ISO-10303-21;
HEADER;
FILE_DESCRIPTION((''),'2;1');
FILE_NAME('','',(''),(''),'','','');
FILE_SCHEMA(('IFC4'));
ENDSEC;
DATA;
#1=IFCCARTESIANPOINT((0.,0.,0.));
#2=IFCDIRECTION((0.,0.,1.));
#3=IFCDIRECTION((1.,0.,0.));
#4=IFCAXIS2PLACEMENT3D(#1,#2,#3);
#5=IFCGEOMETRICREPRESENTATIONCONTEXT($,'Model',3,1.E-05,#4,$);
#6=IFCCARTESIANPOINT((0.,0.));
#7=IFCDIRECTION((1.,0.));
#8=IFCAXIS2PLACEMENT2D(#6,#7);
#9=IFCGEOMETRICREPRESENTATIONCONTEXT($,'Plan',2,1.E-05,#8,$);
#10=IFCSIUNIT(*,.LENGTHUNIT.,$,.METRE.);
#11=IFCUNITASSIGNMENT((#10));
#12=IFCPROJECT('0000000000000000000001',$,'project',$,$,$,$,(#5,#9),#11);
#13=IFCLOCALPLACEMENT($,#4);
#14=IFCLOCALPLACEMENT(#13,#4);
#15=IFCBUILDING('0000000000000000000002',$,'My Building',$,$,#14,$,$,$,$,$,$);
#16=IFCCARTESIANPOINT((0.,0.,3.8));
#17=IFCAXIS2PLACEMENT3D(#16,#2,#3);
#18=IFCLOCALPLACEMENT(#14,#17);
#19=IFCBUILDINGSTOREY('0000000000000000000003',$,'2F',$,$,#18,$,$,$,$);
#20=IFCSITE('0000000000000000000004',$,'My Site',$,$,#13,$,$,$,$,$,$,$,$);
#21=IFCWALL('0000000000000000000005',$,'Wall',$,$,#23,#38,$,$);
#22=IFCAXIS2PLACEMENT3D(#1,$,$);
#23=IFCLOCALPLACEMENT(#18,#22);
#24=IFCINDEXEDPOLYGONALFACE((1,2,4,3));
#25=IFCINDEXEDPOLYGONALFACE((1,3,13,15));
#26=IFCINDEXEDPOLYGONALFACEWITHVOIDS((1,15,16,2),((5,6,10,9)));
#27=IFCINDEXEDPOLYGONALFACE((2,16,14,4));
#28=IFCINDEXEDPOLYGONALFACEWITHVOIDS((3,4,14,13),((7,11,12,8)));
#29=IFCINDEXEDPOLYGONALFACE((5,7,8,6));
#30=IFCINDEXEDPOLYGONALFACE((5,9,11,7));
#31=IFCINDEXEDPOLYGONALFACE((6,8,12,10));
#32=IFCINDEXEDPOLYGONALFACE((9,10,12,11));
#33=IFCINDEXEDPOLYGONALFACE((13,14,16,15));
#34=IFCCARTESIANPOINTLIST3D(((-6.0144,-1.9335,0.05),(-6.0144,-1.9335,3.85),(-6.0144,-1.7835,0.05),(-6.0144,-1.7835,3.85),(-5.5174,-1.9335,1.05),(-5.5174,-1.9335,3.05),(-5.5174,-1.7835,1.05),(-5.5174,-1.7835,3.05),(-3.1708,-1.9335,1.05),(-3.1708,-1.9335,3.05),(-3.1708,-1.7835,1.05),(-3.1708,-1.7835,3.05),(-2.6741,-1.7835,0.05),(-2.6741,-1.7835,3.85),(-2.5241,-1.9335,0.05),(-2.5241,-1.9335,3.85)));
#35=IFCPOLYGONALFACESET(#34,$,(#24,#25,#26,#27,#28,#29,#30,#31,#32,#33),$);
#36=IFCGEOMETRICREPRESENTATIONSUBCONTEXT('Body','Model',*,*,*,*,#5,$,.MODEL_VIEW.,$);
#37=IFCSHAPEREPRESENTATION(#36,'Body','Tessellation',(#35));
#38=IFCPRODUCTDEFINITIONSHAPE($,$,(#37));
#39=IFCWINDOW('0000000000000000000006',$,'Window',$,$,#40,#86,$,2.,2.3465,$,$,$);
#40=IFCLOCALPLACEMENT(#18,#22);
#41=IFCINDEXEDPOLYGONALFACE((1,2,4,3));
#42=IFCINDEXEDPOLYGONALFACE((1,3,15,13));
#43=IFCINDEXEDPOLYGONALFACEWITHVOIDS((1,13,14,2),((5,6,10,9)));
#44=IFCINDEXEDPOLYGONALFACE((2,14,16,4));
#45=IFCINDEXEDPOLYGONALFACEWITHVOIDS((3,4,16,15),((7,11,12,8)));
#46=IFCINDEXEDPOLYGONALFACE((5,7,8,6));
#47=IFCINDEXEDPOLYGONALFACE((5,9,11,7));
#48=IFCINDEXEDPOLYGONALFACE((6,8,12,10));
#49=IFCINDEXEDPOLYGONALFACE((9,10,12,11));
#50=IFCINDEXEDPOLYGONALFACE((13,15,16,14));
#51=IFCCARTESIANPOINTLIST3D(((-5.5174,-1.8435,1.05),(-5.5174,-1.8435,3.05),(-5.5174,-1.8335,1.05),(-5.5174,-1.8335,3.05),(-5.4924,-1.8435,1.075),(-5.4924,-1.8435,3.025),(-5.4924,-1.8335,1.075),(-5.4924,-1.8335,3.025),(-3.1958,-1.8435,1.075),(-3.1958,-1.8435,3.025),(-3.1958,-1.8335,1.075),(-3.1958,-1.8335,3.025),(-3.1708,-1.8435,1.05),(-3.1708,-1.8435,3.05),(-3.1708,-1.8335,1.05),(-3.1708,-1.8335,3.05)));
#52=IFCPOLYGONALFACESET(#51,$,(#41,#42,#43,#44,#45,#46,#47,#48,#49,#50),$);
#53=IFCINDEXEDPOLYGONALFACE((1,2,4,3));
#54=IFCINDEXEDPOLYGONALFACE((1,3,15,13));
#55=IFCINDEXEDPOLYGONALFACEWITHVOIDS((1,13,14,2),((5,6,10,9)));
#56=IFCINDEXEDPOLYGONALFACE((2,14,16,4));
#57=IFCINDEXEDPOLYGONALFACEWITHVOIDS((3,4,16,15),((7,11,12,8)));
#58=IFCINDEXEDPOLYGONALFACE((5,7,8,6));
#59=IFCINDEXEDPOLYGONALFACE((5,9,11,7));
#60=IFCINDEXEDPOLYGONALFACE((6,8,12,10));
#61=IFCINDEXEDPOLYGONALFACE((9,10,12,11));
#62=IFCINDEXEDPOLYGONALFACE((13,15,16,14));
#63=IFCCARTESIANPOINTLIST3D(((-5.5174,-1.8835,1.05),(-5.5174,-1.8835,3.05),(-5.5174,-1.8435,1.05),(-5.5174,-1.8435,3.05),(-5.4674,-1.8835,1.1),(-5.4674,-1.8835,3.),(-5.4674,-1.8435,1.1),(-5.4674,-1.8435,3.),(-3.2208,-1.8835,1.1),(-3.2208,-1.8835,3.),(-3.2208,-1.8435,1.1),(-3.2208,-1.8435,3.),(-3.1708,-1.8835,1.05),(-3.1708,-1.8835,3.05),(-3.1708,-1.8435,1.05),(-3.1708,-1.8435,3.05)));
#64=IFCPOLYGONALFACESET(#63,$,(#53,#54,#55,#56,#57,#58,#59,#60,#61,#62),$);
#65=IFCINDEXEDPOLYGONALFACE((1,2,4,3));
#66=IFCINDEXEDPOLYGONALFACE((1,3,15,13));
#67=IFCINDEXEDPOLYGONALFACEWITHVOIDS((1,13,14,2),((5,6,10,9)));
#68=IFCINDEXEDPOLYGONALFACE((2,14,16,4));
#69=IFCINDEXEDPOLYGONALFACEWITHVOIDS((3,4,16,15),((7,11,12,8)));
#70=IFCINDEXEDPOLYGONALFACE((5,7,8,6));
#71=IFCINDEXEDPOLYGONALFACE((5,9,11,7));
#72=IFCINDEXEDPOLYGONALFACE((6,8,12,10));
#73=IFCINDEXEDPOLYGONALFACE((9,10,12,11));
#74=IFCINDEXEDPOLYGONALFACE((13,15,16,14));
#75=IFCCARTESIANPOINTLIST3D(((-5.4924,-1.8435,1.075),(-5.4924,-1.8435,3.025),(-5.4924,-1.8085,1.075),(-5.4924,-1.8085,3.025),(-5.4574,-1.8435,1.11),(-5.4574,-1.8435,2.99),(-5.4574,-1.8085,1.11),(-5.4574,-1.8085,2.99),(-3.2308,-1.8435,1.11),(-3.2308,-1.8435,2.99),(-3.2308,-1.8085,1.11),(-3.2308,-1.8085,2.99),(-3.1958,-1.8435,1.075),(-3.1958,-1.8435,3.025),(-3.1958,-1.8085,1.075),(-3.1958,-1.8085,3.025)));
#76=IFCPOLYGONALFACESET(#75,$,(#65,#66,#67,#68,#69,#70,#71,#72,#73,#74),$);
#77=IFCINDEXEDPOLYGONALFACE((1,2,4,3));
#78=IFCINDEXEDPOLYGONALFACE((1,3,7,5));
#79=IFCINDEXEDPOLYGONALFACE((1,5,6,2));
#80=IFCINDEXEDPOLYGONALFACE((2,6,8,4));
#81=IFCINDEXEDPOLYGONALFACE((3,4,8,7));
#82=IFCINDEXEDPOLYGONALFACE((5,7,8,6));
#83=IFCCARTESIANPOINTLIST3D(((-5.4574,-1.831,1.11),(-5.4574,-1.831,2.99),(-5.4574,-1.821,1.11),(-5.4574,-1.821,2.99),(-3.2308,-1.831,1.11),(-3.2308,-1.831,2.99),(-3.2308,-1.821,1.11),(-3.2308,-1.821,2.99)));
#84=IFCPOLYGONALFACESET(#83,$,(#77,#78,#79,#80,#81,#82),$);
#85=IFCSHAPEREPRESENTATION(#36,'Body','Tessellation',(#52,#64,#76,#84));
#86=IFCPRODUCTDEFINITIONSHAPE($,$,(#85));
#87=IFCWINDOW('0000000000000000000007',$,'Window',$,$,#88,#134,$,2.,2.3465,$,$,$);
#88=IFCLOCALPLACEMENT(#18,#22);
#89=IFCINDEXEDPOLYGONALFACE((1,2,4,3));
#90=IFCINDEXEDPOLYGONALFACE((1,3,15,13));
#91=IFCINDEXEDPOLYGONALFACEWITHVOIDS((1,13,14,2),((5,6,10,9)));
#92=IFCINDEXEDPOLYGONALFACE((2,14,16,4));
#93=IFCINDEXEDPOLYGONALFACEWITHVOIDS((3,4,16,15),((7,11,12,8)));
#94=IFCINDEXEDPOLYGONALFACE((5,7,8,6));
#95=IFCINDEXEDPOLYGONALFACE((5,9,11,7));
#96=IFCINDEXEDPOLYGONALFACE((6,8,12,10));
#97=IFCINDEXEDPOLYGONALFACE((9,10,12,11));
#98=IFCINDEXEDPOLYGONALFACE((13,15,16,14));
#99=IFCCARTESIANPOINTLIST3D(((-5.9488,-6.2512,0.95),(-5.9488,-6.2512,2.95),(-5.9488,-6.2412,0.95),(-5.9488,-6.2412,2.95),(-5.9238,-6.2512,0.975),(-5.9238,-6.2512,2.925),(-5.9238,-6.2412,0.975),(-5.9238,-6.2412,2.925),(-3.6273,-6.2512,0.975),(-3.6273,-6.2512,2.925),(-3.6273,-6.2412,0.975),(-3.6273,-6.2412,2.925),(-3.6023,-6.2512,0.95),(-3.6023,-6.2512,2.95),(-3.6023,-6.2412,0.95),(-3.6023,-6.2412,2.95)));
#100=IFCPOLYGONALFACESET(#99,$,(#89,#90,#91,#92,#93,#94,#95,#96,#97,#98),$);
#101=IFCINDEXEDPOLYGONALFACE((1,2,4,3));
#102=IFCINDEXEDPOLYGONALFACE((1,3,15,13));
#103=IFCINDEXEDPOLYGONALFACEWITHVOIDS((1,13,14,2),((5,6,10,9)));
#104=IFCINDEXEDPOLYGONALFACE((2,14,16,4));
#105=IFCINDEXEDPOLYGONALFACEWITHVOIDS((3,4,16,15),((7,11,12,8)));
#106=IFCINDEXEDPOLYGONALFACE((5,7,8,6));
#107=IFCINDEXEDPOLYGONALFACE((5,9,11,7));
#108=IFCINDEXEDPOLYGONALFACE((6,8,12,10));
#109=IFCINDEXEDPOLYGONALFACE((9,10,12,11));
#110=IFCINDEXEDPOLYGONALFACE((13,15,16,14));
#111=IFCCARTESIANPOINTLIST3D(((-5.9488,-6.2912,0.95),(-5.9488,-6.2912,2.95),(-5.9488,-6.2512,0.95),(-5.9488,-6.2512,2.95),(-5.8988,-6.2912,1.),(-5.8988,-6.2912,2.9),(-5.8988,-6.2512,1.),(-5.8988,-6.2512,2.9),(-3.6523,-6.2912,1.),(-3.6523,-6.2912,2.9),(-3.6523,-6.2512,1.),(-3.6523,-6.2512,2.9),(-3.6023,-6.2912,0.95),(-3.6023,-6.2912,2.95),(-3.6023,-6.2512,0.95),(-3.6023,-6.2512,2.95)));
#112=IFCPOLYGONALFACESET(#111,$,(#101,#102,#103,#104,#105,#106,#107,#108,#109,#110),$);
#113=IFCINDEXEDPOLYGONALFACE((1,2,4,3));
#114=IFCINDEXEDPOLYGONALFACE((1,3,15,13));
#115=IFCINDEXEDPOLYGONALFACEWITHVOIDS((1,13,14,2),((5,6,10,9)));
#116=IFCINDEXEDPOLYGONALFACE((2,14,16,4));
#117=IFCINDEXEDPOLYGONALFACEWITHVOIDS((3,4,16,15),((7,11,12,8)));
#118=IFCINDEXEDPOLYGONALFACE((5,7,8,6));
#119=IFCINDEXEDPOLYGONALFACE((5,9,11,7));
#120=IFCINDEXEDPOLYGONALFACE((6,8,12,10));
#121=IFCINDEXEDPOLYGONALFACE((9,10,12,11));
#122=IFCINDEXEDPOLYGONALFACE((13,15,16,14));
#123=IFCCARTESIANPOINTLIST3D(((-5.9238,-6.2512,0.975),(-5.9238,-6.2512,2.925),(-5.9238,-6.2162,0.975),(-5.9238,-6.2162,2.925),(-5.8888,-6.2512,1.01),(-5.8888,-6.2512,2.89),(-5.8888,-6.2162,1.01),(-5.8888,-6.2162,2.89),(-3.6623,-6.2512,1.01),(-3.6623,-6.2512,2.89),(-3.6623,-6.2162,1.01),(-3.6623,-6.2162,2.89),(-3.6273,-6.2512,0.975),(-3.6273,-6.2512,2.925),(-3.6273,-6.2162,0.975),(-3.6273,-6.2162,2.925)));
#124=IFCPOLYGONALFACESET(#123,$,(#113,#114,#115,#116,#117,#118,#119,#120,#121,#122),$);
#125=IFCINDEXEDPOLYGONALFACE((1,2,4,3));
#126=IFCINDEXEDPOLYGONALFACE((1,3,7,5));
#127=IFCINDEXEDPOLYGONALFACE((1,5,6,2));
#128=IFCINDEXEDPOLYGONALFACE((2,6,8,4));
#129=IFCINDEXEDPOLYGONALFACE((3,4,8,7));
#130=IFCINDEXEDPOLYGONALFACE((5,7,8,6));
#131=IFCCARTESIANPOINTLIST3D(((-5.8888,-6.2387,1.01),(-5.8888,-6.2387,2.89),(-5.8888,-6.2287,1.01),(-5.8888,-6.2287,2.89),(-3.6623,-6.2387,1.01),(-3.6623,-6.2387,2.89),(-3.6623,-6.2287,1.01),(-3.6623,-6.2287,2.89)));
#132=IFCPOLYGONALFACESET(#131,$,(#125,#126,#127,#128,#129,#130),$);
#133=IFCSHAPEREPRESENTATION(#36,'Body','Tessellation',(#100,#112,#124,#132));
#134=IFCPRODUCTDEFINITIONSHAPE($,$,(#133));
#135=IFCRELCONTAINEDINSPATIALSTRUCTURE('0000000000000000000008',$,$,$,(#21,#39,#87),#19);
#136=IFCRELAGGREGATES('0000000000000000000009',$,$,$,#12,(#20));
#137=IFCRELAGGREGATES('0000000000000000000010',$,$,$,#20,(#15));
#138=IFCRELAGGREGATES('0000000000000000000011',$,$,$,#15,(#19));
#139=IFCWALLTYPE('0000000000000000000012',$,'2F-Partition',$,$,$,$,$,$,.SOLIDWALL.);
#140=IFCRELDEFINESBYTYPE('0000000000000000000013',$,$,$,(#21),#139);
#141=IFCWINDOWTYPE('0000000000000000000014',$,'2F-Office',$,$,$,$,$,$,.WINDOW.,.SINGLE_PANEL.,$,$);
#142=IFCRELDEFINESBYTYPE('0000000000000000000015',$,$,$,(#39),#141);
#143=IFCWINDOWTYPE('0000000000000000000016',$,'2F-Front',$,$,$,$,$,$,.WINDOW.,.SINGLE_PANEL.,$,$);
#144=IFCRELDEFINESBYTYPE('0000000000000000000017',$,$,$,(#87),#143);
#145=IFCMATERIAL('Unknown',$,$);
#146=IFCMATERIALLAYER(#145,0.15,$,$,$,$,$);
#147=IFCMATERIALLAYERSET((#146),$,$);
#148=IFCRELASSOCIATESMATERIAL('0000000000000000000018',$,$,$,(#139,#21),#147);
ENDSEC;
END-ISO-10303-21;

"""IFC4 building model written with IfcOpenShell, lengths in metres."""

from ifc_helpers import new_model, entity, si_unit, frame, origin_with_axes, origin_2d_with_axis, place, context, subcontext, project, spatial, line, indexed_curve, outline, extrude, shape, source, transform, mapped, material, layer, layer_set, layer_usage, type_object, type_shapes, element, fill, save


model = new_model("IFC4")

# Units and contexts
model_context = context("Model", 3, precision=1e-05, world=origin_with_axes())
plan_context = context("Plan", 2, precision=1e-05, world=origin_2d_with_axis())
body_context_1 = subcontext(model_context, "Body", "Model", "MODEL_VIEW")
body_context_2 = subcontext(plan_context, "Body", "Plan", "PLAN_VIEW")
ifc_project = project(units=[si_unit("LENGTHUNIT", "METRE")], contexts=[model_context, plan_context])

# Site, building, storey
site_placement = place(None, origin_with_axes())
site = spatial("IfcSite", under=ifc_project, at=site_placement, Name="My Site")
building_placement = place(site_placement, origin_with_axes())
building = spatial("IfcBuilding", under=site, at=building_placement, Name="My Building")
storey_placement = place(building_placement, frame((0.0, 0.0, 3.8), z_axis=(0.0, 0.0, 1.0), x_axis=(1.0, 0.0, 0.0)))
storey = spatial("IfcBuildingStorey", under=building, at=storey_placement, Name="2F")

# Shared definitions
ifc_material = material(Name="Unknown")

# Shared definitions
ifc_layer_1 = layer(ifc_material, 0.15)
ifc_layer_set_1 = layer_set([ifc_layer_1])
wall_type_1 = type_object("IfcWallType", Name="2F-Partition", PredefinedType="SOLIDWALL", material=ifc_layer_set_1)

# Wall, opening, window
ifc_layer_usage_1 = layer_usage(ifc_layer_set_1, "AXIS2", "POSITIVE", 0.0)
wall_1_placement = place(storey_placement, frame((-2.6741, -1.7835, 0.05), z_axis=(0.0, 0.0, 1.0), x_axis=(-1.0, 0.0, 0.0)))
wall_1 = element("IfcWall", 1, at=wall_1_placement, inside=storey, type_object=wall_type_1, material=ifc_layer_usage_1, Name="Wall", context=body_context_1, shape_type="SweptSolid", body=[
    extrude(outline(indexed_curve([(0.0, 0.0), (-0.15, 0.15), (3.3403, 0.15), (3.3403, 0.0)], segments=[line(1, 2, 3, 4, 1)])), origin_with_axes(), (0.0, 0.0, 1.0), 3.8),
])
shared_shape_1 = source(origin_with_axes(), body_context_1, "Body", "SweptSolid", [
    extrude(outline(indexed_curve([(0.0, 0.0), (2.3465, 0.0), (2.3465, 2.0), (0.0, 2.0)], segments=[line(1, 2, 3, 4, 1)])), frame((0.0, -0.6, 0.0), z_axis=(0.0, -1.0, 0.0), x_axis=(1.0, 0.0, 0.0)), (0.0, 0.0, -1.0), 1.2),
])
opening_1_placement = place(wall_1_placement, frame((2.8433, 0.15, 1.0), z_axis=(0.0, 0.0, 1.0), x_axis=(-1.0, 0.0, 0.0)))
opening_1 = element("IfcOpeningElement", 2, at=opening_1_placement, cuts=wall_1, PredefinedType="OPENING", context=body_context_1, shape_type="MappedRepresentation", body=[
    mapped(shared_shape_1, transform((0.0, 0.0, 0.0), x_axis=(1.0, 0.0, 0.0), y_axis=(0.0, 1.0, 0.0), z_axis=(0.0, 0.0, 1.0), scale=1.0)),
])
window_type_1 = type_object("IfcWindowType", Name="2F-Office", PartitioningType="SINGLE_PANEL", PredefinedType="WINDOW")
shared_shape_2 = source(origin_with_axes(), body_context_1, "Body", "SweptSolid", [
    extrude(outline(indexed_curve([(0.0, 0.0), (2.3465, 0.0), (2.3465, 2.0), (0.0, 2.0)], segments=[line(1, 2, 3, 4, 1)]), holes=[indexed_curve([(0.025, 0.025), (2.3215, 0.025), (2.3215, 1.975), (0.025, 1.975)], segments=[line(1, 2, 3, 4, 1)])]), frame((0.0, 0.09, 0.0), z_axis=(0.0, -1.0, 0.0), x_axis=(1.0, 0.0, 0.0)), (0.0, 0.0, -1.0), 0.01),
    extrude(outline(indexed_curve([(0.0, 0.0), (2.3465, 0.0), (2.3465, 2.0), (0.0, 2.0)], segments=[line(1, 2, 3, 4, 1)]), holes=[indexed_curve([(0.05, 0.05), (2.2965, 0.05), (2.2965, 1.95), (0.05, 1.95)], segments=[line(1, 2, 3, 4, 1)])]), frame((0.0, 0.05, 0.0), z_axis=(0.0, -1.0, 0.0), x_axis=(1.0, 0.0, 0.0)), (0.0, 0.0, -1.0), 0.04),
    extrude(outline(indexed_curve([(0.0, 0.0), (2.2965, 0.0), (2.2965, 1.95), (0.0, 1.95)], segments=[line(1, 2, 3, 4, 1)]), holes=[indexed_curve([(0.035, 0.035), (2.2615, 0.035), (2.2615, 1.915), (0.035, 1.915)], segments=[line(1, 2, 3, 4, 1)])]), frame((0.025, 0.09, 0.025), z_axis=(0.0, -1.0, 0.0), x_axis=(1.0, 0.0, 0.0)), (0.0, 0.0, -1.0), 0.035),
    extrude(outline(indexed_curve([(0.035, 0.035), (2.2615, 0.035), (2.2615, 1.915), (0.035, 1.915)], segments=[line(1, 2, 3, 4, 1)])), frame((0.025, 0.1025, 0.025), z_axis=(0.0, -1.0, 0.0), x_axis=(1.0, 0.0, 0.0)), (0.0, 0.0, -1.0), 0.01),
])
shared_shape_3 = source(origin_with_axes(), body_context_2, "Body", "Curve2D", [
    entity("IfcIndexedPolyCurve", entity("IfcCartesianPointList2D", [[0.05, 0.05], [2.2965, 0.05]])),
    entity("IfcIndexedPolyCurve", entity("IfcCartesianPointList2D", [[0.0, 0.1], [0.025, 0.1], [0.025, 0.09], [0.05, 0.09], [0.05, 0.05], [0.0, 0.05]]), [entity("IfcLineIndex", [1, 2, 3, 4, 5, 6, 1])]),
    entity("IfcIndexedPolyCurve", entity("IfcCartesianPointList2D", [[2.3465, 0.1], [2.3215, 0.1], [2.3215, 0.09], [2.2965, 0.09], [2.2965, 0.05], [2.3465, 0.05]]), [entity("IfcLineIndex", [1, 2, 3, 4, 5, 6, 1])]),
    entity("IfcIndexedPolyCurve", entity("IfcCartesianPointList2D", [[0.025, 0.09], [0.06, 0.09], [0.06, 0.125], [0.025, 0.125]]), [entity("IfcLineIndex", [1, 2, 3, 4, 1])]),
    entity("IfcIndexedPolyCurve", entity("IfcCartesianPointList2D", [[2.3215, 0.09], [2.2865, 0.09], [2.2865, 0.125], [2.3215, 0.125]]), [entity("IfcLineIndex", [1, 2, 3, 4, 1])]),
    entity("IfcIndexedPolyCurve", entity("IfcCartesianPointList2D", [[0.06, 0.09], [2.2865, 0.09]])),
    entity("IfcIndexedPolyCurve", entity("IfcCartesianPointList2D", [[0.06, 0.125], [2.2865, 0.125]])),
    entity("IfcIndexedPolyCurve", entity("IfcCartesianPointList2D", [[0.06, 0.1075], [2.2865, 0.1075]])),
])
type_shapes(window_type_1, [shared_shape_2, shared_shape_3])
window_1_placement = place(opening_1_placement, frame((0.0, 0.0, 0.0), z_axis=(0.0, 0.0, 1.0), x_axis=(1.0, 0.0, 0.0)))
window_1 = element("IfcWindow", 3, at=window_1_placement, inside=storey, type_object=window_type_1, Name="Window", OverallHeight=2.0, OverallWidth=2.3465, shapes=[
    shape(body_context_1, "Body", "MappedRepresentation", [mapped(shared_shape_2, transform((0.0, 0.0, 0.0), x_axis=(1.0, 0.0, 0.0), y_axis=(0.0, 1.0, 0.0), z_axis=(0.0, 0.0, 1.0), scale=1.0))]),
    shape(body_context_2, "Body", "MappedRepresentation", [mapped(shared_shape_3, transform((0.0, 0.0, 0.0), x_axis=(1.0, 0.0, 0.0), y_axis=(0.0, 1.0, 0.0), z_axis=(0.0, 0.0, 1.0), scale=1.0))]),
])
fill(opening_1, window_1)

# Window
window_type_2 = type_object("IfcWindowType", Name="2F-Front", PartitioningType="SINGLE_PANEL", PredefinedType="WINDOW")
shared_shape_4 = source(origin_with_axes(), body_context_1, "Body", "SweptSolid", [
    extrude(outline(indexed_curve([(0.0, 0.0), (2.3465, 0.0), (2.3465, 2.0), (0.0, 2.0)], segments=[line(1, 2, 3, 4, 1)]), holes=[indexed_curve([(0.025, 0.025), (2.3215, 0.025), (2.3215, 1.975), (0.025, 1.975)], segments=[line(1, 2, 3, 4, 1)])]), frame((0.0, 0.09, 0.0), z_axis=(0.0, -1.0, 0.0), x_axis=(1.0, 0.0, 0.0)), (0.0, 0.0, -1.0), 0.01),
    extrude(outline(indexed_curve([(0.0, 0.0), (2.3465, 0.0), (2.3465, 2.0), (0.0, 2.0)], segments=[line(1, 2, 3, 4, 1)]), holes=[indexed_curve([(0.05, 0.05), (2.2965, 0.05), (2.2965, 1.95), (0.05, 1.95)], segments=[line(1, 2, 3, 4, 1)])]), frame((0.0, 0.05, 0.0), z_axis=(0.0, -1.0, 0.0), x_axis=(1.0, 0.0, 0.0)), (0.0, 0.0, -1.0), 0.04),
    extrude(outline(indexed_curve([(0.0, 0.0), (2.2965, 0.0), (2.2965, 1.95), (0.0, 1.95)], segments=[line(1, 2, 3, 4, 1)]), holes=[indexed_curve([(0.035, 0.035), (2.2615, 0.035), (2.2615, 1.915), (0.035, 1.915)], segments=[line(1, 2, 3, 4, 1)])]), frame((0.025, 0.09, 0.025), z_axis=(0.0, -1.0, 0.0), x_axis=(1.0, 0.0, 0.0)), (0.0, 0.0, -1.0), 0.035),
    extrude(outline(indexed_curve([(0.035, 0.035), (2.2615, 0.035), (2.2615, 1.915), (0.035, 1.915)], segments=[line(1, 2, 3, 4, 1)])), frame((0.025, 0.1025, 0.025), z_axis=(0.0, -1.0, 0.0), x_axis=(1.0, 0.0, 0.0)), (0.0, 0.0, -1.0), 0.01),
])
shared_shape_5 = source(origin_with_axes(), body_context_2, "Body", "Curve2D", [
    entity("IfcIndexedPolyCurve", entity("IfcCartesianPointList2D", [[0.05, 0.05], [2.2965, 0.05]])),
    entity("IfcIndexedPolyCurve", entity("IfcCartesianPointList2D", [[0.0, 0.1], [0.025, 0.1], [0.025, 0.09], [0.05, 0.09], [0.05, 0.05], [0.0, 0.05]]), [entity("IfcLineIndex", [1, 2, 3, 4, 5, 6, 1])]),
    entity("IfcIndexedPolyCurve", entity("IfcCartesianPointList2D", [[2.3465, 0.1], [2.3215, 0.1], [2.3215, 0.09], [2.2965, 0.09], [2.2965, 0.05], [2.3465, 0.05]]), [entity("IfcLineIndex", [1, 2, 3, 4, 5, 6, 1])]),
    entity("IfcIndexedPolyCurve", entity("IfcCartesianPointList2D", [[0.025, 0.09], [0.06, 0.09], [0.06, 0.125], [0.025, 0.125]]), [entity("IfcLineIndex", [1, 2, 3, 4, 1])]),
    entity("IfcIndexedPolyCurve", entity("IfcCartesianPointList2D", [[2.3215, 0.09], [2.2865, 0.09], [2.2865, 0.125], [2.3215, 0.125]]), [entity("IfcLineIndex", [1, 2, 3, 4, 1])]),
    entity("IfcIndexedPolyCurve", entity("IfcCartesianPointList2D", [[0.06, 0.09], [2.2865, 0.09]])),
    entity("IfcIndexedPolyCurve", entity("IfcCartesianPointList2D", [[0.06, 0.125], [2.2865, 0.125]])),
    entity("IfcIndexedPolyCurve", entity("IfcCartesianPointList2D", [[0.06, 0.1075], [2.2865, 0.1075]])),
])
type_shapes(window_type_2, [shared_shape_4, shared_shape_5])
window_2_placement = place(storey_placement, frame((-5.9488, -6.3412, 0.95), z_axis=(0.0, 0.0, 1.0), x_axis=(1.0, 0.0, 0.0)))
element("IfcWindow", 4, at=window_2_placement, inside=storey, type_object=window_type_2, Name="Window", OverallHeight=2.0, OverallWidth=2.3465, shapes=[
    shape(body_context_1, "Body", "MappedRepresentation", [mapped(shared_shape_4, transform((0.0, 0.0, 0.0), x_axis=(1.0, 0.0, 0.0), y_axis=(0.0, 1.0, 0.0), z_axis=(0.0, 0.0, 1.0), scale=1.0))]),
    shape(body_context_2, "Body", "MappedRepresentation", [mapped(shared_shape_5, transform((0.0, 0.0, 0.0), x_axis=(1.0, 0.0, 0.0), y_axis=(0.0, 1.0, 0.0), z_axis=(0.0, 0.0, 1.0), scale=1.0))]),
])

save(model, "model.ifc")
